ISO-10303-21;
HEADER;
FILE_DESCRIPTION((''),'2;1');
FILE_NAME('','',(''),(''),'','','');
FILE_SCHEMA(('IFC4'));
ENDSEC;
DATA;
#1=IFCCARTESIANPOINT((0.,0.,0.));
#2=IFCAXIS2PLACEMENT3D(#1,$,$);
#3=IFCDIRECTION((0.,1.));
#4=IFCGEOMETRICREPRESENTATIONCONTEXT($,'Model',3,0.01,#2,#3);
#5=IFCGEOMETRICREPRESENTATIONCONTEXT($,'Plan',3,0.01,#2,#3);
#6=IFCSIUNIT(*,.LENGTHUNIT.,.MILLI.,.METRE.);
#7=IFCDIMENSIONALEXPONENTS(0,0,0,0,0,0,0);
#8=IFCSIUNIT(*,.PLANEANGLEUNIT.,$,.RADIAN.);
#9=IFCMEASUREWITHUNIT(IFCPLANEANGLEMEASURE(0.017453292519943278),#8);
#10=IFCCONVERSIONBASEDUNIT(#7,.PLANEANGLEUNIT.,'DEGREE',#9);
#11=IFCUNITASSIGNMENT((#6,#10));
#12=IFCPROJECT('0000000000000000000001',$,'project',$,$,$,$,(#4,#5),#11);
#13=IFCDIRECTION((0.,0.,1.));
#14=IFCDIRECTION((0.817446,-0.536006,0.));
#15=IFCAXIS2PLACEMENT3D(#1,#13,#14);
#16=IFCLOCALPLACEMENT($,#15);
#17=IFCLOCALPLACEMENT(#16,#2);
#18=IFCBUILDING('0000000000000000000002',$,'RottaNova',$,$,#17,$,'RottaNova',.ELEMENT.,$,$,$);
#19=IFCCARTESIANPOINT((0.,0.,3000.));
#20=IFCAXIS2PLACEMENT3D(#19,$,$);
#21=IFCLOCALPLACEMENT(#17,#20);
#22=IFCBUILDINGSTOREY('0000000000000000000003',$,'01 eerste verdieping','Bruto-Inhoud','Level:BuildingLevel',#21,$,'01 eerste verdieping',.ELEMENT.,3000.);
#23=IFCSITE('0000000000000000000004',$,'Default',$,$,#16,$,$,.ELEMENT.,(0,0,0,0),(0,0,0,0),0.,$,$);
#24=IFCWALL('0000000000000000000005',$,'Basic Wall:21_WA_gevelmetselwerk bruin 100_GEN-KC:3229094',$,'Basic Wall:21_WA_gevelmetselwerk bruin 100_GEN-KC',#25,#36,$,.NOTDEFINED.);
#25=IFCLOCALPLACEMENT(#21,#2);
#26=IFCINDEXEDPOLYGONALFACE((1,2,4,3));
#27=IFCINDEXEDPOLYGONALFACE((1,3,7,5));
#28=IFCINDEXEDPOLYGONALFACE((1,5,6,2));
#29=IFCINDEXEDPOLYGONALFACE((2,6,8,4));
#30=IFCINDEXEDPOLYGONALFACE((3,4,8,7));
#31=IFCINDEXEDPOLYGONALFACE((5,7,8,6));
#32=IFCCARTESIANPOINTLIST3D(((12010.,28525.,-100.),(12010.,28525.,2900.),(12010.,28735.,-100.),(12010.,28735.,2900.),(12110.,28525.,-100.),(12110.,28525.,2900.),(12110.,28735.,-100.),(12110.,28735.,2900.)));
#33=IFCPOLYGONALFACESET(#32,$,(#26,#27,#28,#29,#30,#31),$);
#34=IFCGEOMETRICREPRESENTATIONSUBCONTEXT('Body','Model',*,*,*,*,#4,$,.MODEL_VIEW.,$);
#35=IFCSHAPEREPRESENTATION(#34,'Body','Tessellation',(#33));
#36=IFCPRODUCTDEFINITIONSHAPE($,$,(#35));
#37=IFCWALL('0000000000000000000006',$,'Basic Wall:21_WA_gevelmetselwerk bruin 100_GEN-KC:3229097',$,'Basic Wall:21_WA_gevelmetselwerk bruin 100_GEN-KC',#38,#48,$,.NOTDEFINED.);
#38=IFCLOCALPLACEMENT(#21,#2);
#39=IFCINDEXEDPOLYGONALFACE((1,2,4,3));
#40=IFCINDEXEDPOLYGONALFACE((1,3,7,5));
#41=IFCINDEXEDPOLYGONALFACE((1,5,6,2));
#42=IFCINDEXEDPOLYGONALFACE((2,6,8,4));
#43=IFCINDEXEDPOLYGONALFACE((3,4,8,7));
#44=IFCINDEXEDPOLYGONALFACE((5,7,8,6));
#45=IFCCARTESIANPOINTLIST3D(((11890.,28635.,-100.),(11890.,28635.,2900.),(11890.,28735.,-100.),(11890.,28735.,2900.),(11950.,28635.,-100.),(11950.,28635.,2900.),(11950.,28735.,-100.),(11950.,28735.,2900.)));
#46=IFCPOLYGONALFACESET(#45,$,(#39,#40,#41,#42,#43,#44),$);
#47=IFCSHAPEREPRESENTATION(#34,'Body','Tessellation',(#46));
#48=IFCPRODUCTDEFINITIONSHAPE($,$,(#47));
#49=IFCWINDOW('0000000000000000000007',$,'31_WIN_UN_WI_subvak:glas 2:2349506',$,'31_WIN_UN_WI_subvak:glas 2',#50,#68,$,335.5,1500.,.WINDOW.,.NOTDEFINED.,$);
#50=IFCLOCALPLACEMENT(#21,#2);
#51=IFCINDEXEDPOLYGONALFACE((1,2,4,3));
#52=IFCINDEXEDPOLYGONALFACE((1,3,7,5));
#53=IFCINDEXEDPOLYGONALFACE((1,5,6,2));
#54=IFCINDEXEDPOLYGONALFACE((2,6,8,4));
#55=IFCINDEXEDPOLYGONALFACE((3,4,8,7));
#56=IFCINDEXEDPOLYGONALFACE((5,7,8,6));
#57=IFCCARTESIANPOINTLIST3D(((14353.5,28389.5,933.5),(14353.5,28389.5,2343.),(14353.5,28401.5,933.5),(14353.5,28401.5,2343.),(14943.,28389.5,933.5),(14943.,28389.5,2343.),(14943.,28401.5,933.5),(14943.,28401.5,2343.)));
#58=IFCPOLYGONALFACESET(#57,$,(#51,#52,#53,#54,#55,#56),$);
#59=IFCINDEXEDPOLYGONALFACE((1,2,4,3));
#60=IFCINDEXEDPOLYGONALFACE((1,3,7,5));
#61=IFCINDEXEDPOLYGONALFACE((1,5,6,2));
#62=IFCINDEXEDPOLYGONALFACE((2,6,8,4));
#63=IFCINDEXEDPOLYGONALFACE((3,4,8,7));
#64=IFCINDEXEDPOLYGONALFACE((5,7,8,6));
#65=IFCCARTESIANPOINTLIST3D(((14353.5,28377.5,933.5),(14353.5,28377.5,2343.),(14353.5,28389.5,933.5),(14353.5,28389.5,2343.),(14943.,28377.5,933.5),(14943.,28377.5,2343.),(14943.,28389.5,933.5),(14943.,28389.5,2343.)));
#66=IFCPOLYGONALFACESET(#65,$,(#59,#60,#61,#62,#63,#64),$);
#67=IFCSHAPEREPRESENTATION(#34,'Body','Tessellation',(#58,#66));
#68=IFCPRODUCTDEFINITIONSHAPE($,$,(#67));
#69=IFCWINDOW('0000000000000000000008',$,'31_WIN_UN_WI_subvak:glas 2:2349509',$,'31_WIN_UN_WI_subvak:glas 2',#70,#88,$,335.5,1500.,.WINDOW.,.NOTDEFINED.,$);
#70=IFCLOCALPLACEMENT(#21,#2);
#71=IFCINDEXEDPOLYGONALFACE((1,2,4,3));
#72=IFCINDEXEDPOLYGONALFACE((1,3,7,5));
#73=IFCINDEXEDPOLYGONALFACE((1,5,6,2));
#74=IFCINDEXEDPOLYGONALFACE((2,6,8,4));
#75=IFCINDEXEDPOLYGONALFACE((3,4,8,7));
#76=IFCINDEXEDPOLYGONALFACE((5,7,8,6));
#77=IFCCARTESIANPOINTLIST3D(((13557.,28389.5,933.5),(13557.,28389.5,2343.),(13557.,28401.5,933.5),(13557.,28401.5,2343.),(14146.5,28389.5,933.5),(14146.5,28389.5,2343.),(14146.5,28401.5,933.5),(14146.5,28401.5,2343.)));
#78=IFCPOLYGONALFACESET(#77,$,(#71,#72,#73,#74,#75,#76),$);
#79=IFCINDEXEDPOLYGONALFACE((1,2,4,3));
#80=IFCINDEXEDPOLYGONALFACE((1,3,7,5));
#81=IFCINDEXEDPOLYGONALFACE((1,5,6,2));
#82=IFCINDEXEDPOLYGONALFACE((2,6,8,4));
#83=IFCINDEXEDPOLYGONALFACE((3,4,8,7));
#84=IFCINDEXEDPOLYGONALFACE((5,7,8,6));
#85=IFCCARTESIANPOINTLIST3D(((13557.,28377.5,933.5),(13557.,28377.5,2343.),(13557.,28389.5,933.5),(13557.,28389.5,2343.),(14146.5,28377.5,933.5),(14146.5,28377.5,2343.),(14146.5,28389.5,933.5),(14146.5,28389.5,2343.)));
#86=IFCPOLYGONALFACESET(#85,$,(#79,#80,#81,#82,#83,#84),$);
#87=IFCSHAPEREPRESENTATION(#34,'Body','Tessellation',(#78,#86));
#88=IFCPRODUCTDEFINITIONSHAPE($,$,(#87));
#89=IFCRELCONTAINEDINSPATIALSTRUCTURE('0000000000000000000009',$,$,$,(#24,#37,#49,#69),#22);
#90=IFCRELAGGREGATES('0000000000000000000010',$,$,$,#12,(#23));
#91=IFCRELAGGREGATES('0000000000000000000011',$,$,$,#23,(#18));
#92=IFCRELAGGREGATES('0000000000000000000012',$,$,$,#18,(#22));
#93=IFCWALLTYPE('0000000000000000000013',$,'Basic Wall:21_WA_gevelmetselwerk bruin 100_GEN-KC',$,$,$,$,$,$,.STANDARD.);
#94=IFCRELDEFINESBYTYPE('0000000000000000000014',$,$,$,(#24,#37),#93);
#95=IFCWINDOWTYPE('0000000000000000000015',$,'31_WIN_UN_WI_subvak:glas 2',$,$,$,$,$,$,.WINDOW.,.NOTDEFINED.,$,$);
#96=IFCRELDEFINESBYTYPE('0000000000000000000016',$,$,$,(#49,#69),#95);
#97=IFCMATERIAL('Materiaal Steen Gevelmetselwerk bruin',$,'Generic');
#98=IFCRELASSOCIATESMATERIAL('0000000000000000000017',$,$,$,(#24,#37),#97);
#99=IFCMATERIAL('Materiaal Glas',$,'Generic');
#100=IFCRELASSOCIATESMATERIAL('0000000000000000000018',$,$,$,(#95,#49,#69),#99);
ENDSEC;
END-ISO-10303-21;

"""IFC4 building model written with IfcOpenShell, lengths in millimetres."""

from ifc_helpers import new_model, entity, si_unit, converted_unit, direction, frame, origin, place, context, subcontext, project, spatial, indexed_curve, outline, extrude, source, transform, mapped, material, type_object, type_shapes, element, save


model = new_model("IFC4")

# Units and contexts
model_context = context("Model", 3, precision=0.01, world=origin(), true_north=direction((0.0, 1.0)))
plan_context = context("Plan", 3, precision=0.01, world=origin(), true_north=direction((0.0, 1.0)))
body_context = subcontext(model_context, "Body", "Model", "MODEL_VIEW")
ifc_project = project(units=[si_unit("LENGTHUNIT", "METRE", prefix="MILLI"), converted_unit("PLANEANGLEUNIT", "DEGREE", entity("IfcPlaneAngleMeasure", 0.017453292519943278), si_unit("PLANEANGLEUNIT", "RADIAN"), dimensions=[0, 0, 0, 0, 0, 0, 0])], contexts=[model_context, plan_context])

# Site, building, storey
site_placement = place(None, frame((0.0, 0.0, 0.0), z_axis=(0.0, 0.0, 1.0), x_axis=(0.817446, -0.536006, 0.0)))
site = spatial("IfcSite", under=ifc_project, at=site_placement, Name="Default", CompositionType="ELEMENT", RefLatitude=(0, 0, 0, 0), RefLongitude=(0, 0, 0, 0), RefElevation=0.0)
building_placement = place(site_placement, origin())
building = spatial("IfcBuilding", under=site, at=building_placement, Name="RottaNova", LongName="RottaNova", CompositionType="ELEMENT")
storey_placement = place(building_placement, frame((0.0, 0.0, 3000.0)))
storey = spatial("IfcBuildingStorey", under=building, at=storey_placement, Name="01 eerste verdieping", Description="Bruto-Inhoud", ObjectType="Level:BuildingLevel", LongName="01 eerste verdieping", CompositionType="ELEMENT", Elevation=3000.0)

# Shared definitions
ifc_material_1 = material(Name="Materiaal Glas", Category="Generic")

# Walls
ifc_material_2 = material(Name="Materiaal Steen Gevelmetselwerk bruin", Category="Generic")
wall_type = type_object("IfcWallType", Name="Basic Wall:21_WA_gevelmetselwerk bruin 100_GEN-KC", PredefinedType="STANDARD")
wall_1_placement = place(storey_placement, frame((12060.0, 28735.0, -100.0), z_axis=(0.0, 0.0, 1.0), x_axis=(0.0, -1.0, 0.0)))
element("IfcWall", 1, at=wall_1_placement, inside=storey, type_object=wall_type, material=ifc_material_2, Name="Basic Wall:21_WA_gevelmetselwerk bruin 100_GEN-KC:3229094", ObjectType="Basic Wall:21_WA_gevelmetselwerk bruin 100_GEN-KC", PredefinedType="NOTDEFINED", context=body_context, shape_type="SweptSolid", body=[
    extrude(outline(indexed_curve([(210.0, 50.0), (0.0, 50.0), (0.0, -50.0), (210.0, -50.0), (210.0, 50.0)], self_intersect=False)), origin(), (0.0, 0.0, 1.0), 3000.0),
])
wall_2_placement = place(storey_placement, frame((11890.0, 28685.0, -100.0)))
element("IfcWall", 2, at=wall_2_placement, inside=storey, type_object=wall_type, material=ifc_material_2, Name="Basic Wall:21_WA_gevelmetselwerk bruin 100_GEN-KC:3229097", ObjectType="Basic Wall:21_WA_gevelmetselwerk bruin 100_GEN-KC", PredefinedType="NOTDEFINED", context=body_context, shape_type="SweptSolid", body=[
    extrude(outline(indexed_curve([(60.0, 50.0), (0.0, 50.0), (0.0, -50.0), (60.0, -50.0), (60.0, 50.0)], self_intersect=False)), origin(), (0.0, 0.0, 1.0), 3000.0),
])

# Windows
window_type = type_object("IfcWindowType", Name="31_WIN_UN_WI_subvak:glas 2", PartitioningType="NOTDEFINED", PredefinedType="WINDOW", material=ifc_material_1)
shared_shape_1 = source(origin(), body_context, "Body", "SweptSolid", [
    extrude(outline(indexed_curve([(-294.7, -6.0), (294.7, -6.0), (294.7, 6.0), (-294.7, 6.0), (-294.7, -6.0)], self_intersect=False)), frame((0.0, -6.0, 0.0)), (0.0, 0.0, 1.0), 1409.5),
    extrude(outline(indexed_curve([(-294.8, -6.0), (294.8, -6.0), (294.8, 6.0), (-294.8, 6.0), (-294.8, -6.0)], self_intersect=False)), frame((0.0, 6.0, 0.0)), (0.0, 0.0, 1.0), 1409.5),
])
type_shapes(window_type, [shared_shape_1])
for number, where, z_axis, x_axis, name in (
    (3, (14648.3, 28389.5, 933.5), (0.0, 0.0, 1.0), (-1.0, 0.0, 0.0), "31_WIN_UN_WI_subvak:glas 2:2349506"),
    (4, (13851.8, 28389.5, 933.5), (0.0, 0.0, 1.0), (-1.0, 0.0, 0.0), "31_WIN_UN_WI_subvak:glas 2:2349509"),
):
    element("IfcWindow", number, at=place(storey_placement, frame(where, z_axis=z_axis, x_axis=x_axis)), inside=storey, type_object=window_type, material=ifc_material_1, Name=name, ObjectType="31_WIN_UN_WI_subvak:glas 2", OverallHeight=335.5, OverallWidth=1500.0, PartitioningType="NOTDEFINED", PredefinedType="WINDOW", context=body_context, shape_type="MappedRepresentation", body=[
        mapped(shared_shape_1, transform((0.0, 0.0, 0.0), scale=1.0)),
    ])

save(model, "model.ifc")
